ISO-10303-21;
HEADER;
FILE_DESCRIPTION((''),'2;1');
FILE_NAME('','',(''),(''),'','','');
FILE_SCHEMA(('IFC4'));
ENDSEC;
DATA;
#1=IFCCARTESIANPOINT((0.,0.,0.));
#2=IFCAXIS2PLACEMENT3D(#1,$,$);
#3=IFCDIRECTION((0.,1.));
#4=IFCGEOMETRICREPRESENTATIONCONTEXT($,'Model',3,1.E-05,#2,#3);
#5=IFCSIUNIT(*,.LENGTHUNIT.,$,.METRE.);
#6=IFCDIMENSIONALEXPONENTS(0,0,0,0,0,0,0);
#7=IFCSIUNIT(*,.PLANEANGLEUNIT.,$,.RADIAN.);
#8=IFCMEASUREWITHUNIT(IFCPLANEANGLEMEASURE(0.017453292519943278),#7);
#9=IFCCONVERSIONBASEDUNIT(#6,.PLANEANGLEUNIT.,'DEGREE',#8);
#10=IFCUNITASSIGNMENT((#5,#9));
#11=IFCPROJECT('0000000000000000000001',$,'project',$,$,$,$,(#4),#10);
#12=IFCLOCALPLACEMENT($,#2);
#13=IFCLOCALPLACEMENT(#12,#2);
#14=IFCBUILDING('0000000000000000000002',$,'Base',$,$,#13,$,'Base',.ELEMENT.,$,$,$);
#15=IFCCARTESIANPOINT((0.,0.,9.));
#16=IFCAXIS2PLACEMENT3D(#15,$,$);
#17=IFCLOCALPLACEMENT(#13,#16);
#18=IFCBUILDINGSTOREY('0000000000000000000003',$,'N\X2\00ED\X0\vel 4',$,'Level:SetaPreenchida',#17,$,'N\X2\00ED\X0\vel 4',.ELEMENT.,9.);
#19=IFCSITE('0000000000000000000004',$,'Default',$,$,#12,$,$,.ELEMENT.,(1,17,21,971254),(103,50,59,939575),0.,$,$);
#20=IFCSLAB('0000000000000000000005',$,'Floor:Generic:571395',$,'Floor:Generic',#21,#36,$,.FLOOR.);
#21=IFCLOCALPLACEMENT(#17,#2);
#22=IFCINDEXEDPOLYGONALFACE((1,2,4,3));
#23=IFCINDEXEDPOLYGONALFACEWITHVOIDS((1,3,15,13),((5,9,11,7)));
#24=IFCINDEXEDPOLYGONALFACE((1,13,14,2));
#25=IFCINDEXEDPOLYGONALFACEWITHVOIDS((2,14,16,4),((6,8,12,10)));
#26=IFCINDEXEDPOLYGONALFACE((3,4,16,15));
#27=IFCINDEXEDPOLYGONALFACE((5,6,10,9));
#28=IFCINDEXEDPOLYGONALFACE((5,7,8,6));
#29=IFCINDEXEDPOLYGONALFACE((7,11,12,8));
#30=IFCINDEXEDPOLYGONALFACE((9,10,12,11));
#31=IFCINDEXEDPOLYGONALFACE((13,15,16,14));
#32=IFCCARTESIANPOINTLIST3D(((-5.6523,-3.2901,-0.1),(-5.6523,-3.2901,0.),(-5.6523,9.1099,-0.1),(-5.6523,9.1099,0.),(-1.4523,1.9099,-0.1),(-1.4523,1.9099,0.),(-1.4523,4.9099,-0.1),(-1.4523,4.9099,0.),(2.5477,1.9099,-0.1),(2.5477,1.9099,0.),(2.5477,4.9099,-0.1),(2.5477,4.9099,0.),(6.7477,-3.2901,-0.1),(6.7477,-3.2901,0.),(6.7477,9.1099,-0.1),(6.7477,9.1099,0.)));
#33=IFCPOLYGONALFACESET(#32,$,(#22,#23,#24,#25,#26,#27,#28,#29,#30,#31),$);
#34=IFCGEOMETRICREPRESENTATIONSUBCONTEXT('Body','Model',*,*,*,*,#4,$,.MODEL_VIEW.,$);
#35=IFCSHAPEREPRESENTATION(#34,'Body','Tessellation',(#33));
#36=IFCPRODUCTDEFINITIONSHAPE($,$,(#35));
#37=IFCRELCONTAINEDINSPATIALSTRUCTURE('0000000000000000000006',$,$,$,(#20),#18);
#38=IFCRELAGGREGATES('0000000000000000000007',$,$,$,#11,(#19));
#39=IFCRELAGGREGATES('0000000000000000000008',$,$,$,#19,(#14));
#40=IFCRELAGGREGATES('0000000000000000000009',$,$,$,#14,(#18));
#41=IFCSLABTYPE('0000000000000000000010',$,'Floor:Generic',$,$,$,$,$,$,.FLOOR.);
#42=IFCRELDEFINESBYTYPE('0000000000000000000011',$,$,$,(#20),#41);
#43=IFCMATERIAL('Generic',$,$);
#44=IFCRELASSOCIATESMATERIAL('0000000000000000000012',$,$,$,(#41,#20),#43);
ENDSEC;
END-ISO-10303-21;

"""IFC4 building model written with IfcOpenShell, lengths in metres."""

from ifc_helpers import new_model, entity, si_unit, converted_unit, direction, frame, origin, place, context, subcontext, project, spatial, indexed_curve, outline, extrude, material, type_object, element, save


model = new_model("IFC4")

# Units and contexts
model_context = context("Model", 3, precision=1e-05, world=origin(), true_north=direction((0.0, 1.0)))
body_context = subcontext(model_context, "Body", "Model", "MODEL_VIEW")
ifc_project = project(units=[si_unit("LENGTHUNIT", "METRE"), converted_unit("PLANEANGLEUNIT", "DEGREE", entity("IfcPlaneAngleMeasure", 0.017453292519943278), si_unit("PLANEANGLEUNIT", "RADIAN"), dimensions=[0, 0, 0, 0, 0, 0, 0])], contexts=[model_context])

# Site, building, storey
site_placement = place(None, origin())
site = spatial("IfcSite", under=ifc_project, at=site_placement, Name="Default", CompositionType="ELEMENT", RefLatitude=(1, 17, 21, 971254), RefLongitude=(103, 50, 59, 939575), RefElevation=0.0)
building_placement = place(site_placement, origin())
building = spatial("IfcBuilding", under=site, at=building_placement, Name="Base", LongName="Base", CompositionType="ELEMENT")
storey_placement = place(building_placement, frame((0.0, 0.0, 9.0)))
storey = spatial("IfcBuildingStorey", under=building, at=storey_placement, Name="Nível 4", ObjectType="Level:SetaPreenchida", LongName="Nível 4", CompositionType="ELEMENT", Elevation=9.0)

# Slab, opening
ifc_material = material(Name="Generic")
slab_type = type_object("IfcSlabType", Name="Floor:Generic", PredefinedType="FLOOR", material=ifc_material)
slab_placement = place(storey_placement, origin())
slab = element("IfcSlab", 1, at=slab_placement, inside=storey, type_object=slab_type, material=ifc_material, Name="Floor:Generic:571395", ObjectType="Floor:Generic", PredefinedType="FLOOR", context=body_context, shape_type="SweptSolid", body=[
    extrude(outline(indexed_curve([(-6.2, -6.2), (6.2, -6.2), (6.2, 6.2), (-6.2, 6.2), (-6.2, -6.2)], self_intersect=False), holes=[indexed_curve([(2.0, 1.0), (2.0, -2.0), (-2.0, -2.0), (-2.0, 1.0), (2.0, 1.0)], self_intersect=False)]), frame((0.5477, 2.9099, -0.1), z_axis=(0.0, 0.0, 1.0), x_axis=(-1.0, 0.0, 0.0)), (0.0, 0.0, 1.0), 0.1),
])
opening_placement = place(slab_placement, origin())
element("IfcOpeningElement", 2, at=opening_placement, cuts=slab, PredefinedType="OPENING", context=body_context, shape_type="SweptSolid", body=[
    extrude(outline(indexed_curve([(-1.5, -2.0), (1.5, -2.0), (1.5, 2.0), (-1.5, 2.0), (-1.5, -2.0)], self_intersect=False)), frame((0.5477, 3.4099, 0.0), z_axis=(0.0, 0.0, -1.0), x_axis=(0.0, 1.0, 0.0)), (0.0, 0.0, 1.0), 12.4),
])

save(model, "model.ifc")
